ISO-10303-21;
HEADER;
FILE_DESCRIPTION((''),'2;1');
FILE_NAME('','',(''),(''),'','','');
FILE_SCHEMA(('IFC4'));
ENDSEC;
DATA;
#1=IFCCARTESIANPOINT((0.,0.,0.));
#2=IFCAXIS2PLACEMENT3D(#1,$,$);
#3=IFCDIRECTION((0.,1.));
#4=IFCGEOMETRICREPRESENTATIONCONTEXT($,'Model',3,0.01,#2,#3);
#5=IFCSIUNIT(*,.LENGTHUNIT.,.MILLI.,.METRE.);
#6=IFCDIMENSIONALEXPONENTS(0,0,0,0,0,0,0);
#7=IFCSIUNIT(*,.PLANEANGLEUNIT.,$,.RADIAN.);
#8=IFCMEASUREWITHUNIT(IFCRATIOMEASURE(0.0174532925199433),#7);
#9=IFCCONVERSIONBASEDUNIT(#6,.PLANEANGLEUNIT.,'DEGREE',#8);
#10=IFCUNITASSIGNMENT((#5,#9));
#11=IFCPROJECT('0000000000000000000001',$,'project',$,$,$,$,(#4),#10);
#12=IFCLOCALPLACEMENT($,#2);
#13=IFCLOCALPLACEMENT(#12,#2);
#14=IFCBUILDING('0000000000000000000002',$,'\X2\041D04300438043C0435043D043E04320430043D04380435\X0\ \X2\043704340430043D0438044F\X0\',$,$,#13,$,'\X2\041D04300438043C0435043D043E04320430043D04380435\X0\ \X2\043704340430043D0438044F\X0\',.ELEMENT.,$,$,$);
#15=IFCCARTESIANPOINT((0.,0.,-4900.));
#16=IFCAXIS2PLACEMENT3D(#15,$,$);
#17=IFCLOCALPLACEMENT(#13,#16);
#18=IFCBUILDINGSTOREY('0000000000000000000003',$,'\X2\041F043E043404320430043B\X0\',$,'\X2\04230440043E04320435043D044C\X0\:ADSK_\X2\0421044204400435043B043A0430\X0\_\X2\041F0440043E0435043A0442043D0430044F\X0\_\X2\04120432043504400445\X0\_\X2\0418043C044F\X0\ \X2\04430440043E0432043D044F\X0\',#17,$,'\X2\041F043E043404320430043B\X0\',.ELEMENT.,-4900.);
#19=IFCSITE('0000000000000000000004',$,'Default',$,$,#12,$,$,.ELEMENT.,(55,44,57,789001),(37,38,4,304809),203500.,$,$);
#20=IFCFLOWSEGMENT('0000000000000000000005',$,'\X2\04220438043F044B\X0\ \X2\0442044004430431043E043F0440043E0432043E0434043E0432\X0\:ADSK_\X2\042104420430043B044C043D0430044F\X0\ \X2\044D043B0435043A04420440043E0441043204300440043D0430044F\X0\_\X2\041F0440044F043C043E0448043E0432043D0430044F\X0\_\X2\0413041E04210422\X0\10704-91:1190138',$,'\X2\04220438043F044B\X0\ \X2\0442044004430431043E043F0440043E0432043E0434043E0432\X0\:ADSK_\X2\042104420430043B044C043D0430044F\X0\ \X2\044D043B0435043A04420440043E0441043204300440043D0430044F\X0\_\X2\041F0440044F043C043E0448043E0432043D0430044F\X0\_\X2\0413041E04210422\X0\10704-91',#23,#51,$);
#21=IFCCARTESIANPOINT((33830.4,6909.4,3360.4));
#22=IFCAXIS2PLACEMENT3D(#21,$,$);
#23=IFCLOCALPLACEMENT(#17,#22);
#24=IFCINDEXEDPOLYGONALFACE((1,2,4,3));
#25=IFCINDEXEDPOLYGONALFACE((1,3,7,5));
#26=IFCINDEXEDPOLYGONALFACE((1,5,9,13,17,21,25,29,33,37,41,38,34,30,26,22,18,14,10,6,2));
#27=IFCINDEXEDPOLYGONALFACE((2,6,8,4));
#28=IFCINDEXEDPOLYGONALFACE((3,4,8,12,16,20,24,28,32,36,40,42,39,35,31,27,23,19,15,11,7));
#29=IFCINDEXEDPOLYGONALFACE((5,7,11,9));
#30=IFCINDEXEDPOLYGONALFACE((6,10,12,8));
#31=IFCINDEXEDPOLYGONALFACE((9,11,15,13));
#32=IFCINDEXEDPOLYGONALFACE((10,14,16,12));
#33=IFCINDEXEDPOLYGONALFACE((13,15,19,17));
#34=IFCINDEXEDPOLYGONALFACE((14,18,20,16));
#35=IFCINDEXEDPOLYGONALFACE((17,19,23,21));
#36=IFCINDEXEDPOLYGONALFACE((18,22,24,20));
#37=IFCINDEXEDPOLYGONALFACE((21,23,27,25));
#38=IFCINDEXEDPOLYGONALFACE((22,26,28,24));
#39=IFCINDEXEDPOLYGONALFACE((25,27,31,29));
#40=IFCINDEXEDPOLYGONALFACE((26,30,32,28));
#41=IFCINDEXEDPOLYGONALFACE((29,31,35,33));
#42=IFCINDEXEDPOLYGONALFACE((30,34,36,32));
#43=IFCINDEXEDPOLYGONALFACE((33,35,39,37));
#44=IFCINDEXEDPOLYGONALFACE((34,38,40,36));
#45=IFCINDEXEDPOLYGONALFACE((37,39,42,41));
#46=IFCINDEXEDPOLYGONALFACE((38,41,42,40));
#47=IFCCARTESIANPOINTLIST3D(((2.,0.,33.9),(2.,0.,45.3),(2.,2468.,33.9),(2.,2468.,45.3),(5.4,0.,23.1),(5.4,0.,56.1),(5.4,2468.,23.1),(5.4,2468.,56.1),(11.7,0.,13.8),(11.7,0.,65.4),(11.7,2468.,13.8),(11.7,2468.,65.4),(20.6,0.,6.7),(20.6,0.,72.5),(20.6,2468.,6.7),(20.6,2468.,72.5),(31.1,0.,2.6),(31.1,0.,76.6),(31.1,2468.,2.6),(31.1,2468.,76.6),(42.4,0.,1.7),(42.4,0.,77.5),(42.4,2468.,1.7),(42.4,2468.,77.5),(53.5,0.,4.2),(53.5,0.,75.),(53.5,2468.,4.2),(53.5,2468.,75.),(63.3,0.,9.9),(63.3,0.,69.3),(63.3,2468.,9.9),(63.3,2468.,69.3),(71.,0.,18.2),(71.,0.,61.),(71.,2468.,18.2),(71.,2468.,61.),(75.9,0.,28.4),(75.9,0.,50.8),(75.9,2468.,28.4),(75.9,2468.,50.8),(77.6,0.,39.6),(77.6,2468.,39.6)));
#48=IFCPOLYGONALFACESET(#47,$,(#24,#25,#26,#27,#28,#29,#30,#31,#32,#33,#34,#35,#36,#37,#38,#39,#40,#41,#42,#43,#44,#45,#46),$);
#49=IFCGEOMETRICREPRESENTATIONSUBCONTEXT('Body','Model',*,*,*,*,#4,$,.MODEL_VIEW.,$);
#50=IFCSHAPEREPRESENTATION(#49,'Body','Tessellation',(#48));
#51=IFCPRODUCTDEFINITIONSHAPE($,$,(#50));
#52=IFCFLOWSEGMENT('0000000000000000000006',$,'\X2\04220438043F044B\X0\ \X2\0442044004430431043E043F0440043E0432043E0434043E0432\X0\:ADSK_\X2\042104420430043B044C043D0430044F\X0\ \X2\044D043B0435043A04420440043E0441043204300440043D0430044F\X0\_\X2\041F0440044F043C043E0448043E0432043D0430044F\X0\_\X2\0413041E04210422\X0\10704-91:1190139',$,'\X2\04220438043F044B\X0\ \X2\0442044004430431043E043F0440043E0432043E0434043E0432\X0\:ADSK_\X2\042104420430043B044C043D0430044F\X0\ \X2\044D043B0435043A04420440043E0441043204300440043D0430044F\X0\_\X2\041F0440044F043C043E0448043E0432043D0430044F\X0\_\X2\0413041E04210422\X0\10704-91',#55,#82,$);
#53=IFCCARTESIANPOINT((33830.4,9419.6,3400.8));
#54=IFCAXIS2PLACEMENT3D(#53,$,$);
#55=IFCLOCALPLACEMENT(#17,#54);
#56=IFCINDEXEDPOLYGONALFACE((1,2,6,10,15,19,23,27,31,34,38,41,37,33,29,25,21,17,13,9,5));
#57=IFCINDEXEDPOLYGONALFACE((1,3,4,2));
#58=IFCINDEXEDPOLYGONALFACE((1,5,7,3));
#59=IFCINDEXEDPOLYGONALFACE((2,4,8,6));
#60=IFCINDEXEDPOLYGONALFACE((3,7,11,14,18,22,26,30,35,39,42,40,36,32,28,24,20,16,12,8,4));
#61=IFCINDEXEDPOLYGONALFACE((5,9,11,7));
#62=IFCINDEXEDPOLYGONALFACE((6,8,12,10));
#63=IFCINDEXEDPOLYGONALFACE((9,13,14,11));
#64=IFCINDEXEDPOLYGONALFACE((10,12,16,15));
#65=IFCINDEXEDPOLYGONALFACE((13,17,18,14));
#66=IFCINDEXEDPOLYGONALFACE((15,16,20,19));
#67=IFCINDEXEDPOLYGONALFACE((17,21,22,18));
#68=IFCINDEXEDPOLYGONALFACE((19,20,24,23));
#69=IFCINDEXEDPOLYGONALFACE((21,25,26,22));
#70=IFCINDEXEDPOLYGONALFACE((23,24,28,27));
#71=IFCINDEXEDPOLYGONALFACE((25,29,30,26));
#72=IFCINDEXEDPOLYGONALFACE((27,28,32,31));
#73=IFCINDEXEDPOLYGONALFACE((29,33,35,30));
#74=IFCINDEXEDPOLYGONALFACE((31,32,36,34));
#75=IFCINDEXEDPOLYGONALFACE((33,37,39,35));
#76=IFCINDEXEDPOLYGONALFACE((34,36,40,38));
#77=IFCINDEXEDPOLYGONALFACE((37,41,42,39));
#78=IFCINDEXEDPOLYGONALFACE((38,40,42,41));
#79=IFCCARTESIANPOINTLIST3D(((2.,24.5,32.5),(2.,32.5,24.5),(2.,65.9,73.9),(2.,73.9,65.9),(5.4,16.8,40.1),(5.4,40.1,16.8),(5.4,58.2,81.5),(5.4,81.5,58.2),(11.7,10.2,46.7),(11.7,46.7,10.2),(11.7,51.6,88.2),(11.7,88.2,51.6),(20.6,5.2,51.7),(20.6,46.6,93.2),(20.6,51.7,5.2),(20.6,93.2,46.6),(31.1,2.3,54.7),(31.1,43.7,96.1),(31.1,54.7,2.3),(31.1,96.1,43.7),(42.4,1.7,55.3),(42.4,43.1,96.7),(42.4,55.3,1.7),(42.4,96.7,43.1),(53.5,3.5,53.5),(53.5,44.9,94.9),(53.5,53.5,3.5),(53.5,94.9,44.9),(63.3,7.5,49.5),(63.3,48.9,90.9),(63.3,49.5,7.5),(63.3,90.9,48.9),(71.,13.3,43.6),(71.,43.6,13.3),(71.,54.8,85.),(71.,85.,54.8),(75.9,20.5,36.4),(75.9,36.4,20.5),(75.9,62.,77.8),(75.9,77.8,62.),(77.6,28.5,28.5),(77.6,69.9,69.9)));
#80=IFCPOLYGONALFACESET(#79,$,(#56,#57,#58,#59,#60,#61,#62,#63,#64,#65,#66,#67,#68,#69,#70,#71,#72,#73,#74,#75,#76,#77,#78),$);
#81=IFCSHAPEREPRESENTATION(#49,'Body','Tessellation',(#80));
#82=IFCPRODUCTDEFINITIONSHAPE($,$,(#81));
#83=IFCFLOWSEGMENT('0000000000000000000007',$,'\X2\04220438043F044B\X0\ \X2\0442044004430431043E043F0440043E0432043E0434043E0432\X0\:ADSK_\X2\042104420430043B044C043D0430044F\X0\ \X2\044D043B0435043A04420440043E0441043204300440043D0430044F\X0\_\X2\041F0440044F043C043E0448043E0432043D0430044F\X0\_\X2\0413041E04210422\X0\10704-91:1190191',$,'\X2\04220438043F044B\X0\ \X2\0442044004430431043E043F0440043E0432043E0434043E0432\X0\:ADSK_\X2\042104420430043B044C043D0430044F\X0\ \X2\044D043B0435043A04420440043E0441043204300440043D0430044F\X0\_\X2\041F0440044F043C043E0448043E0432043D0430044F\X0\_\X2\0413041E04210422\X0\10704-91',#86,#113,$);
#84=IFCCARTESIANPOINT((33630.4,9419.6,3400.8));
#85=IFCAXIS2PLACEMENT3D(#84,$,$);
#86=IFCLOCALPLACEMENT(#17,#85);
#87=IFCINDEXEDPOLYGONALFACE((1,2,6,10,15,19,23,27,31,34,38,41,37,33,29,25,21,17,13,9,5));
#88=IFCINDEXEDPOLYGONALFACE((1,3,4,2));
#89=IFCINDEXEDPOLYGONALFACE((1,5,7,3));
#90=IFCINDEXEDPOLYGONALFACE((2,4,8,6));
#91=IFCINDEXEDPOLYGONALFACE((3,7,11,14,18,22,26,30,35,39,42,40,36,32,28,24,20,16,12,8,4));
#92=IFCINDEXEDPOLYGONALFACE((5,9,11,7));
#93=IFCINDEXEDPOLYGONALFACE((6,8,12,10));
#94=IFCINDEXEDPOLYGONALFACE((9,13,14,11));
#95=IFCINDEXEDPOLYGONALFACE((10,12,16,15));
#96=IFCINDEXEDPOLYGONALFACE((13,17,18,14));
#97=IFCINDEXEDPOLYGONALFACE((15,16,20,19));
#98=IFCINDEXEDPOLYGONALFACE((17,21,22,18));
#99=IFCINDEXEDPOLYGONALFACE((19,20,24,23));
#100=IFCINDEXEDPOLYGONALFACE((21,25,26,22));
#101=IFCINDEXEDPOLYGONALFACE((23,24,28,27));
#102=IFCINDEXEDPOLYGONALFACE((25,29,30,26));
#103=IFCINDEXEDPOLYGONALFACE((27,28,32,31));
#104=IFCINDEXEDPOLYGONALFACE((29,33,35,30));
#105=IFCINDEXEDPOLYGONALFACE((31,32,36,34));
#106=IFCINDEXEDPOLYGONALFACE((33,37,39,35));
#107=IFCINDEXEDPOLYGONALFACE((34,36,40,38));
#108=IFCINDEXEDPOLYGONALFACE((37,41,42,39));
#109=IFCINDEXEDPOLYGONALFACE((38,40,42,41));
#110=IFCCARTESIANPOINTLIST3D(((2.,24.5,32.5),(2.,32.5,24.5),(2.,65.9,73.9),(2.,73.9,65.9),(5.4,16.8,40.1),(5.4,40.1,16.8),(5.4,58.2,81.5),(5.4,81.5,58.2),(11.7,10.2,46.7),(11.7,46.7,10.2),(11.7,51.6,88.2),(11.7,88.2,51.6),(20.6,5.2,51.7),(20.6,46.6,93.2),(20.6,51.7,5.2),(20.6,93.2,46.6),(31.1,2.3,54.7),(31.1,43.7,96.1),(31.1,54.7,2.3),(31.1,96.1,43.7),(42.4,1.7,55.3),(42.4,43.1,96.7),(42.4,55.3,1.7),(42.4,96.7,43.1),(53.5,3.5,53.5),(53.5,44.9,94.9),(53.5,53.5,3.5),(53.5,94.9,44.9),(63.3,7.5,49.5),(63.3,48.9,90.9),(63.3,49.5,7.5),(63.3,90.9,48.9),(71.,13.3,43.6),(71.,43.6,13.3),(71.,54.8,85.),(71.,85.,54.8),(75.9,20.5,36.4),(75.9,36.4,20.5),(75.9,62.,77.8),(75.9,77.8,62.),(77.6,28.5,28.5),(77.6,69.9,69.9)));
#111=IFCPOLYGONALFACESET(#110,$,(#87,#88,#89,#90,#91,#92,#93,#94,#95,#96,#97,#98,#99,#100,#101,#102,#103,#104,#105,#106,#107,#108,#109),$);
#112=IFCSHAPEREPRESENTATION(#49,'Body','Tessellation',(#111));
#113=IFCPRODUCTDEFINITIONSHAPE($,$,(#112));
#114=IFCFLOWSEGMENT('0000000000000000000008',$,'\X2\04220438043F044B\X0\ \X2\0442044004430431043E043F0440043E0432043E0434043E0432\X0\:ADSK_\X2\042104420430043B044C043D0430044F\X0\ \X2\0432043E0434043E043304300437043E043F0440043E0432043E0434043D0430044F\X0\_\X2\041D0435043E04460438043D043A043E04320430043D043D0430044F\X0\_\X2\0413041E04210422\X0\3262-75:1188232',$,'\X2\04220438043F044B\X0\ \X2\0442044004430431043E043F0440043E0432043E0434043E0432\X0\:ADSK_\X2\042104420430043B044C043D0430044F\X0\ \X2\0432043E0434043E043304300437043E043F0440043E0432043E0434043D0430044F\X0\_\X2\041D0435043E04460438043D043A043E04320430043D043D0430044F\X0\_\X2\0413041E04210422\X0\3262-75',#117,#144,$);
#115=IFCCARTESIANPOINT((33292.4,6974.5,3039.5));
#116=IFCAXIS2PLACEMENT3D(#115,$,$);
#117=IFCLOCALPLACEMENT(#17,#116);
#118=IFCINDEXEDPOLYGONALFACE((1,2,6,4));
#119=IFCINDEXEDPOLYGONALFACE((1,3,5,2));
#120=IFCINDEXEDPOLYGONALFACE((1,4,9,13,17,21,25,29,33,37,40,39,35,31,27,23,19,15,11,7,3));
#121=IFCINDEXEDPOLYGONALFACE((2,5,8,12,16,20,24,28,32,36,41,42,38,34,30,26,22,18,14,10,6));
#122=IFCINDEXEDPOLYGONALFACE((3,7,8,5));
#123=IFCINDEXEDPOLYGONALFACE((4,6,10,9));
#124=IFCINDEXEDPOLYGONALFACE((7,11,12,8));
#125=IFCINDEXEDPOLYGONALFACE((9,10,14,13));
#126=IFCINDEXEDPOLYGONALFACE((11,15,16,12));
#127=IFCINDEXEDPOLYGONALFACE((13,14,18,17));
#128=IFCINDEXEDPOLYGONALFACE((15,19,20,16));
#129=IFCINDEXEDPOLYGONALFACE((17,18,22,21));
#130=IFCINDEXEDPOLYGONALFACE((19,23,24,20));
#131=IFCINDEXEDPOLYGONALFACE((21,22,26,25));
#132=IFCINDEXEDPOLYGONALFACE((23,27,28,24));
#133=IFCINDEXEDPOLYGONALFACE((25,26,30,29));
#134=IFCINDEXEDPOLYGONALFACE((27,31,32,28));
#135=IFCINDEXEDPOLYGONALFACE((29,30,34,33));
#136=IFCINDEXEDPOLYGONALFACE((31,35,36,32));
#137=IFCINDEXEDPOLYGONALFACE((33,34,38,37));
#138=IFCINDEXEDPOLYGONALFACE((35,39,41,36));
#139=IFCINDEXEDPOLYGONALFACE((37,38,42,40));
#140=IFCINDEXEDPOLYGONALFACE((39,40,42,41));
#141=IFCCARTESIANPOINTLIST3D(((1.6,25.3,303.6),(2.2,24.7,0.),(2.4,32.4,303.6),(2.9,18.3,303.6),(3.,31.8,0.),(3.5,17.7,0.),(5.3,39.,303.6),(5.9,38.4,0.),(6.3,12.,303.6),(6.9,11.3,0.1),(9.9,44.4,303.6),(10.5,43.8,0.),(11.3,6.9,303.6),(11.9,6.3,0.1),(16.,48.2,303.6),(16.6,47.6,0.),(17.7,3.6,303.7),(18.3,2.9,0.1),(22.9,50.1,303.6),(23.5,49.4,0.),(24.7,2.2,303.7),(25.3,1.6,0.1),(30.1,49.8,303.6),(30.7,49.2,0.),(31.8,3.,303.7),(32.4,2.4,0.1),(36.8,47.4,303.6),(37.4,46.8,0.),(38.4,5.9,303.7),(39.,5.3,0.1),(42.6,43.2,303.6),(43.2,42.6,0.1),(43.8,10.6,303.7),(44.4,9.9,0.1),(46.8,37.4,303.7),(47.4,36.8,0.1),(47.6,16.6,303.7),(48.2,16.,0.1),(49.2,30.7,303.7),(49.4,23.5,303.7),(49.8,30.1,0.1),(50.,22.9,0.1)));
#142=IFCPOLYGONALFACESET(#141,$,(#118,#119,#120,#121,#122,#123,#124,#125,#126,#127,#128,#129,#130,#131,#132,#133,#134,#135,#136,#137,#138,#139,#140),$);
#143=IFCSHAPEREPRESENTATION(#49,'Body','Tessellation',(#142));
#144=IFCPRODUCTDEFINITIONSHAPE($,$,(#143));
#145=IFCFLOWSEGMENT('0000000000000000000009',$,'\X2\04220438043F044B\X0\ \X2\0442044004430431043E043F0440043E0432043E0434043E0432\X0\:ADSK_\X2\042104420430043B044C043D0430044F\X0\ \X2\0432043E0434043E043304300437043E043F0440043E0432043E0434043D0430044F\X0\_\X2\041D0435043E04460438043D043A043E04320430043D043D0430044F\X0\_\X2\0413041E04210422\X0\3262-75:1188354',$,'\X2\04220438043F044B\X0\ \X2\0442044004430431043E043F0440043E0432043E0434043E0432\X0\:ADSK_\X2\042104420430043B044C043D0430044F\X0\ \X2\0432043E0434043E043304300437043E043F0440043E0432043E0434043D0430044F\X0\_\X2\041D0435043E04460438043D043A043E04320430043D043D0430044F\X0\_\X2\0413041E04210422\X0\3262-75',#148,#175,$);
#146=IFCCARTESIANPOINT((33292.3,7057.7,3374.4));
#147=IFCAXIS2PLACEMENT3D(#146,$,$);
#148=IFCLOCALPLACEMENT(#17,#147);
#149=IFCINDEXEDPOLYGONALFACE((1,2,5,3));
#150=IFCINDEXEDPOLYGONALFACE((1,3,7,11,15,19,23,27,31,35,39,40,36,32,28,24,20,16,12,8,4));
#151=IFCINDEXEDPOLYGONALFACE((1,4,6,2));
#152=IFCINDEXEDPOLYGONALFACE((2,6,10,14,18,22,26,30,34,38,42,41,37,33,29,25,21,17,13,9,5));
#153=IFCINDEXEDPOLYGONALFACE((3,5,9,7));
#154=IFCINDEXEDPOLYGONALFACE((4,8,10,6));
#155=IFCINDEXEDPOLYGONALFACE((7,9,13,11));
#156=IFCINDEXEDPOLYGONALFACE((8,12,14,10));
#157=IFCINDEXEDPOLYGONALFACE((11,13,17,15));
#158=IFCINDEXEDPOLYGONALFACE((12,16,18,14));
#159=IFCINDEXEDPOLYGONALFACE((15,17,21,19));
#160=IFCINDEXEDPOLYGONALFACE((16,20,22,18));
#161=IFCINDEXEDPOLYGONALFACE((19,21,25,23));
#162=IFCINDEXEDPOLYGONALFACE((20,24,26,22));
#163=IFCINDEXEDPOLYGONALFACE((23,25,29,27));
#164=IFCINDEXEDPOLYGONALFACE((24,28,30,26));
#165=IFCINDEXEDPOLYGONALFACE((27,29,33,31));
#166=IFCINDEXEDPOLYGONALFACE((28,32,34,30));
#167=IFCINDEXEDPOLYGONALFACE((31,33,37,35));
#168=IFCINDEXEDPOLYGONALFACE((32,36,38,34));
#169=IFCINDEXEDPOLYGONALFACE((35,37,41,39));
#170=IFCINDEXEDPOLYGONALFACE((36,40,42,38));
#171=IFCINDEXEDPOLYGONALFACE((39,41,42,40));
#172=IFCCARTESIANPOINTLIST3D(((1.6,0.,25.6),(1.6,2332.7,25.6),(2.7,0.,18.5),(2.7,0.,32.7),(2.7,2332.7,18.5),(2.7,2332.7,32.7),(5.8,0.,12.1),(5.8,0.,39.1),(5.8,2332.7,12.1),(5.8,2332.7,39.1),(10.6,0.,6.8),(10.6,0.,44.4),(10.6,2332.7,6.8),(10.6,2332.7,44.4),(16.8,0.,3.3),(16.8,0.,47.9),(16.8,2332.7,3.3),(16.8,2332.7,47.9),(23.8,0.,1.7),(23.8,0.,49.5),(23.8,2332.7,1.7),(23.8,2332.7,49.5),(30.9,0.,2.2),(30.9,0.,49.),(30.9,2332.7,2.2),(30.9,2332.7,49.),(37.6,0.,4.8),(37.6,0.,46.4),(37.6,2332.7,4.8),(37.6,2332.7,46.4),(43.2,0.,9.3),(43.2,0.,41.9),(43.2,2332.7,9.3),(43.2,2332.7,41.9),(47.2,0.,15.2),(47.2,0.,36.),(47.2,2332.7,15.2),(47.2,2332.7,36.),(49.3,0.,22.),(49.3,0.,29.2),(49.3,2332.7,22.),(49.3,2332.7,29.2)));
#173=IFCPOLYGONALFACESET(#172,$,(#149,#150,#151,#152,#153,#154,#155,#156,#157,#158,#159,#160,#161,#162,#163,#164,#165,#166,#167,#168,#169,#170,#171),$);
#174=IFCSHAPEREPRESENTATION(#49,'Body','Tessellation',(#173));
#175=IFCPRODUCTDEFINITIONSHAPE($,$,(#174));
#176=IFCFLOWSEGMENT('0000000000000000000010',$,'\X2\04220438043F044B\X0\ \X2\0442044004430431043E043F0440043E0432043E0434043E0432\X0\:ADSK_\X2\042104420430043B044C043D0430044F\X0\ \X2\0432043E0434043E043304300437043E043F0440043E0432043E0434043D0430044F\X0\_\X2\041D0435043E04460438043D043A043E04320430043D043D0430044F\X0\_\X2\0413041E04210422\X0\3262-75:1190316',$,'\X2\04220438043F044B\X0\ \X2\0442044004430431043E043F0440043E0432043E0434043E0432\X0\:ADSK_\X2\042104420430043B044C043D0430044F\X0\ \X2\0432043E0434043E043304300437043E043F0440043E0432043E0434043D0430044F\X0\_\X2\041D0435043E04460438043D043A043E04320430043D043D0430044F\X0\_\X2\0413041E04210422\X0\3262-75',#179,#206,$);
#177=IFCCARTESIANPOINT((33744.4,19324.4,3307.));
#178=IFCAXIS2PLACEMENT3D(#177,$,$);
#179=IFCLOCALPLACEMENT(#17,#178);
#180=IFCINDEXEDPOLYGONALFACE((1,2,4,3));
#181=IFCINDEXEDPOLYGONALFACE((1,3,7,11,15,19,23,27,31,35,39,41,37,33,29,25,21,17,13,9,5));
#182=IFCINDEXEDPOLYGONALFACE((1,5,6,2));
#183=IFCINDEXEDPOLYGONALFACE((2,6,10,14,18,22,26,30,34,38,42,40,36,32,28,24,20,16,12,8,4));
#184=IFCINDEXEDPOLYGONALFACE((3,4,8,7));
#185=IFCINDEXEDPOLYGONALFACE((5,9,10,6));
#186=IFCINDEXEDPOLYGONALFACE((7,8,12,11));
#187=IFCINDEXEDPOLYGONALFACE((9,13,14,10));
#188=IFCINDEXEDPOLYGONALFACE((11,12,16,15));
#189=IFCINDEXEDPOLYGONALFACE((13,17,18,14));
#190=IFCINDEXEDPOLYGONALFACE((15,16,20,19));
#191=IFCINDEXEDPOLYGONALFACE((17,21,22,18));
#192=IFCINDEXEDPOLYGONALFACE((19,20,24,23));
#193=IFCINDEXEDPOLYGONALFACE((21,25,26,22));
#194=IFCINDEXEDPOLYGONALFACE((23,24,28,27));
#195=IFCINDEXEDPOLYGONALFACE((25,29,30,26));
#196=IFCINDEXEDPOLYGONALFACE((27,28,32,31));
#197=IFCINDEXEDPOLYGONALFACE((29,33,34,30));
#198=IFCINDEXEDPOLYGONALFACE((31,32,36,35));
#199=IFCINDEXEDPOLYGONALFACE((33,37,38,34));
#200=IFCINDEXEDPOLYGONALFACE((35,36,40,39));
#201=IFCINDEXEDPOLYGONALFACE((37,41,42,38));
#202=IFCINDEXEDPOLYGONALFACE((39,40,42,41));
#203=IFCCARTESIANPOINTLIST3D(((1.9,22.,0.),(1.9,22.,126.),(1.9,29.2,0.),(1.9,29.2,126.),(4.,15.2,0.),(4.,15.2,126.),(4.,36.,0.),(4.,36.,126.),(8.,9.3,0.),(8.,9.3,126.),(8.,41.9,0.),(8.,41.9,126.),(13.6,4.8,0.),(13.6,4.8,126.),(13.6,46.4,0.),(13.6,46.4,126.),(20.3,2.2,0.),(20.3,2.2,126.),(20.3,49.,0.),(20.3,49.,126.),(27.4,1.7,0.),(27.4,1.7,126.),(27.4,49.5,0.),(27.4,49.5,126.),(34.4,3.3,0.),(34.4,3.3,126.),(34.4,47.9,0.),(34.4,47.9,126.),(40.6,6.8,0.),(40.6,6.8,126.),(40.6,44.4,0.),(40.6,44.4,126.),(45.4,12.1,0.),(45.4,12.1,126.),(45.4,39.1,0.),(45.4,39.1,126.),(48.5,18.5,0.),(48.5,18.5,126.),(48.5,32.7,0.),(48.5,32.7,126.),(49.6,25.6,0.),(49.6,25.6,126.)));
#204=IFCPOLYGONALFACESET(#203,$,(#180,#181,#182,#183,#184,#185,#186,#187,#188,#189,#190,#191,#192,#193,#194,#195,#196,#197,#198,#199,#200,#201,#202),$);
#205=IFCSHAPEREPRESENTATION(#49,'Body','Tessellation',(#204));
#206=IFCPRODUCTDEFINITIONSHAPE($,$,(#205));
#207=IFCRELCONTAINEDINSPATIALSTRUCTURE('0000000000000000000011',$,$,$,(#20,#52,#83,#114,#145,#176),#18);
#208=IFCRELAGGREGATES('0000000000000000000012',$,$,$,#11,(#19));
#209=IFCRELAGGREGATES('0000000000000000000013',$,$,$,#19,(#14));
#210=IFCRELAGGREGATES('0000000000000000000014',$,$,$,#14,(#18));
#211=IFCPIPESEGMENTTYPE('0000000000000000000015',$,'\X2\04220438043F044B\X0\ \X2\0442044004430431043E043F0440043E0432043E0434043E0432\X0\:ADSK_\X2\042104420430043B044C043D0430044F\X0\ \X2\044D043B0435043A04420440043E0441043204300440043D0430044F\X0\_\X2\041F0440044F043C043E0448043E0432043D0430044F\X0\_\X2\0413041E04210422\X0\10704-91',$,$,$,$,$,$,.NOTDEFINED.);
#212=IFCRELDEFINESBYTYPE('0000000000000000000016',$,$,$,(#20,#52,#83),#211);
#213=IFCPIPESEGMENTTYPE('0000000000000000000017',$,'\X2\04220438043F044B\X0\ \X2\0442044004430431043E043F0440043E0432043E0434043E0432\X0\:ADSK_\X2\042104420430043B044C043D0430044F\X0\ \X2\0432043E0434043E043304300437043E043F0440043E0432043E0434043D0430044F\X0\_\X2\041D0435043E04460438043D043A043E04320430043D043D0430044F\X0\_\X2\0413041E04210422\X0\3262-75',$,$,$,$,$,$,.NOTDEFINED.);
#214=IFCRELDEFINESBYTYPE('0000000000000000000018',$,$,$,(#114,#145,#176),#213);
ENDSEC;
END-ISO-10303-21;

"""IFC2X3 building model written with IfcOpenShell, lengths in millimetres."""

from ifc_helpers import new_model, entity, si_unit, converted_unit, direction, frame, origin, origin_2d_with_axis, place, context, subcontext, project, spatial, circle, extrude, type_object, element, save


model = new_model("IFC2X3")

# Units and contexts
model_context = context("Model", 3, precision=0.01, world=origin(), true_north=direction((0.0, 1.0)))
body_context = subcontext(model_context, "Body", "Model", "MODEL_VIEW")
ifc_project = project(units=[si_unit("LENGTHUNIT", "METRE", prefix="MILLI"), converted_unit("PLANEANGLEUNIT", "DEGREE", entity("IfcRatioMeasure", 0.0174532925199433), si_unit("PLANEANGLEUNIT", "RADIAN"), dimensions=[0, 0, 0, 0, 0, 0, 0])], contexts=[model_context])

# Site, building, storey
site_placement = place(None, origin())
site = spatial("IfcSite", under=ifc_project, at=site_placement, Name="Default", CompositionType="ELEMENT", RefLatitude=(55, 44, 57, 789001), RefLongitude=(37, 38, 4, 304809), RefElevation=203500.0)
building_placement = place(site_placement, origin())
building = spatial("IfcBuilding", under=site, at=building_placement, Name="Наименование здания", LongName="Наименование здания", CompositionType="ELEMENT")
storey_placement = place(building_placement, frame((0.0, 0.0, -4900.0)))
storey = spatial("IfcBuildingStorey", under=building, at=storey_placement, Name="Подвал", ObjectType="Уровень:ADSK_Стрелка_Проектная_Вверх_Имя уровня", LongName="Подвал", CompositionType="ELEMENT", Elevation=-4900.0)

# Flow segments
pipe_segment_type_1 = type_object("IfcPipeSegmentType", Name="Типы трубопроводов:ADSK_Стальная электросварная_Прямошовная_ГОСТ10704-91", PredefinedType="NOTDEFINED")
flow_segment_1_placement = place(storey_placement, frame((33830.4, 6909.4, 3360.4)))
element("IfcFlowSegment", 1, at=flow_segment_1_placement, inside=storey, type_object=pipe_segment_type_1, Name="Типы трубопроводов:ADSK_Стальная электросварная_Прямошовная_ГОСТ10704-91:1190138", ObjectType="Типы трубопроводов:ADSK_Стальная электросварная_Прямошовная_ГОСТ10704-91", context=body_context, shape_type="SweptSolid", body=[
    extrude(circle(Radius=38.0, at=origin_2d_with_axis()), frame((39.6, 0.0, 39.6), z_axis=(0.0, 1.0, 0.0), x_axis=(1.0, 0.0, 0.0)), (0.0, 0.0, 1.0), 2468.0),
])
flow_segment_2_placement = place(storey_placement, frame((33830.4, 9419.6, 3400.8)))
element("IfcFlowSegment", 2, at=flow_segment_2_placement, inside=storey, type_object=pipe_segment_type_1, Name="Типы трубопроводов:ADSK_Стальная электросварная_Прямошовная_ГОСТ10704-91:1190139", ObjectType="Типы трубопроводов:ADSK_Стальная электросварная_Прямошовная_ГОСТ10704-91", context=body_context, shape_type="SweptSolid", body=[
    extrude(circle(Radius=38.0, at=origin_2d_with_axis()), frame((39.6, 28.5, 28.5), z_axis=(0.0, 0.707107, 0.707107), x_axis=(1.0, 0.0, 0.0)), (0.0, 0.0, 1.0), 58.6),
])
flow_segment_3_placement = place(storey_placement, frame((33630.4, 9419.6, 3400.8)))
element("IfcFlowSegment", 3, at=flow_segment_3_placement, inside=storey, type_object=pipe_segment_type_1, Name="Типы трубопроводов:ADSK_Стальная электросварная_Прямошовная_ГОСТ10704-91:1190191", ObjectType="Типы трубопроводов:ADSK_Стальная электросварная_Прямошовная_ГОСТ10704-91", context=body_context, shape_type="SweptSolid", body=[
    extrude(circle(Radius=38.0, at=origin_2d_with_axis()), frame((39.6, 28.5, 28.5), z_axis=(0.0, 0.707107, 0.707107), x_axis=(1.0, 0.0, 0.0)), (0.0, 0.0, 1.0), 58.6),
])
pipe_segment_type_2 = type_object("IfcPipeSegmentType", Name="Типы трубопроводов:ADSK_Стальная водогазопроводная_Неоцинкованная_ГОСТ3262-75", PredefinedType="NOTDEFINED")
flow_segment_4_placement = place(storey_placement, frame((33292.4, 6974.5, 3039.5)))
element("IfcFlowSegment", 4, at=flow_segment_4_placement, inside=storey, type_object=pipe_segment_type_2, Name="Типы трубопроводов:ADSK_Стальная водогазопроводная_Неоцинкованная_ГОСТ3262-75:1188232", ObjectType="Типы трубопроводов:ADSK_Стальная водогазопроводная_Неоцинкованная_ГОСТ3262-75", context=body_context, shape_type="SweptSolid", body=[
    extrude(circle(Radius=24.0, at=origin_2d_with_axis()), frame((26.2, 25.6, 0.1), z_axis=(-0.002, 0.002, 0.999996), x_axis=(0.707106, 0.707107, 0.0)), (0.0, 0.0, 1.0), 303.6),
])
flow_segment_5_placement = place(storey_placement, frame((33292.3, 7057.7, 3374.4)))
element("IfcFlowSegment", 5, at=flow_segment_5_placement, inside=storey, type_object=pipe_segment_type_2, Name="Типы трубопроводов:ADSK_Стальная водогазопроводная_Неоцинкованная_ГОСТ3262-75:1188354", ObjectType="Типы трубопроводов:ADSK_Стальная водогазопроводная_Неоцинкованная_ГОСТ3262-75", context=body_context, shape_type="SweptSolid", body=[
    extrude(circle(Radius=24.0, at=origin_2d_with_axis()), frame((25.6, 0.0, 25.6), z_axis=(0.0, 1.0, 0.0), x_axis=(-1.0, 0.0, 0.0)), (0.0, 0.0, 1.0), 2332.7),
])
flow_segment_6_placement = place(storey_placement, frame((33744.4, 19324.4, 3307.0)))
element("IfcFlowSegment", 6, at=flow_segment_6_placement, inside=storey, type_object=pipe_segment_type_2, Name="Типы трубопроводов:ADSK_Стальная водогазопроводная_Неоцинкованная_ГОСТ3262-75:1190316", ObjectType="Типы трубопроводов:ADSK_Стальная водогазопроводная_Неоцинкованная_ГОСТ3262-75", context=body_context, shape_type="SweptSolid", body=[
    extrude(circle(Radius=24.0, at=origin_2d_with_axis()), frame((25.6, 25.6, 0.0)), (0.0, 0.0, 1.0), 126.0),
])

save(model, "model.ifc")
